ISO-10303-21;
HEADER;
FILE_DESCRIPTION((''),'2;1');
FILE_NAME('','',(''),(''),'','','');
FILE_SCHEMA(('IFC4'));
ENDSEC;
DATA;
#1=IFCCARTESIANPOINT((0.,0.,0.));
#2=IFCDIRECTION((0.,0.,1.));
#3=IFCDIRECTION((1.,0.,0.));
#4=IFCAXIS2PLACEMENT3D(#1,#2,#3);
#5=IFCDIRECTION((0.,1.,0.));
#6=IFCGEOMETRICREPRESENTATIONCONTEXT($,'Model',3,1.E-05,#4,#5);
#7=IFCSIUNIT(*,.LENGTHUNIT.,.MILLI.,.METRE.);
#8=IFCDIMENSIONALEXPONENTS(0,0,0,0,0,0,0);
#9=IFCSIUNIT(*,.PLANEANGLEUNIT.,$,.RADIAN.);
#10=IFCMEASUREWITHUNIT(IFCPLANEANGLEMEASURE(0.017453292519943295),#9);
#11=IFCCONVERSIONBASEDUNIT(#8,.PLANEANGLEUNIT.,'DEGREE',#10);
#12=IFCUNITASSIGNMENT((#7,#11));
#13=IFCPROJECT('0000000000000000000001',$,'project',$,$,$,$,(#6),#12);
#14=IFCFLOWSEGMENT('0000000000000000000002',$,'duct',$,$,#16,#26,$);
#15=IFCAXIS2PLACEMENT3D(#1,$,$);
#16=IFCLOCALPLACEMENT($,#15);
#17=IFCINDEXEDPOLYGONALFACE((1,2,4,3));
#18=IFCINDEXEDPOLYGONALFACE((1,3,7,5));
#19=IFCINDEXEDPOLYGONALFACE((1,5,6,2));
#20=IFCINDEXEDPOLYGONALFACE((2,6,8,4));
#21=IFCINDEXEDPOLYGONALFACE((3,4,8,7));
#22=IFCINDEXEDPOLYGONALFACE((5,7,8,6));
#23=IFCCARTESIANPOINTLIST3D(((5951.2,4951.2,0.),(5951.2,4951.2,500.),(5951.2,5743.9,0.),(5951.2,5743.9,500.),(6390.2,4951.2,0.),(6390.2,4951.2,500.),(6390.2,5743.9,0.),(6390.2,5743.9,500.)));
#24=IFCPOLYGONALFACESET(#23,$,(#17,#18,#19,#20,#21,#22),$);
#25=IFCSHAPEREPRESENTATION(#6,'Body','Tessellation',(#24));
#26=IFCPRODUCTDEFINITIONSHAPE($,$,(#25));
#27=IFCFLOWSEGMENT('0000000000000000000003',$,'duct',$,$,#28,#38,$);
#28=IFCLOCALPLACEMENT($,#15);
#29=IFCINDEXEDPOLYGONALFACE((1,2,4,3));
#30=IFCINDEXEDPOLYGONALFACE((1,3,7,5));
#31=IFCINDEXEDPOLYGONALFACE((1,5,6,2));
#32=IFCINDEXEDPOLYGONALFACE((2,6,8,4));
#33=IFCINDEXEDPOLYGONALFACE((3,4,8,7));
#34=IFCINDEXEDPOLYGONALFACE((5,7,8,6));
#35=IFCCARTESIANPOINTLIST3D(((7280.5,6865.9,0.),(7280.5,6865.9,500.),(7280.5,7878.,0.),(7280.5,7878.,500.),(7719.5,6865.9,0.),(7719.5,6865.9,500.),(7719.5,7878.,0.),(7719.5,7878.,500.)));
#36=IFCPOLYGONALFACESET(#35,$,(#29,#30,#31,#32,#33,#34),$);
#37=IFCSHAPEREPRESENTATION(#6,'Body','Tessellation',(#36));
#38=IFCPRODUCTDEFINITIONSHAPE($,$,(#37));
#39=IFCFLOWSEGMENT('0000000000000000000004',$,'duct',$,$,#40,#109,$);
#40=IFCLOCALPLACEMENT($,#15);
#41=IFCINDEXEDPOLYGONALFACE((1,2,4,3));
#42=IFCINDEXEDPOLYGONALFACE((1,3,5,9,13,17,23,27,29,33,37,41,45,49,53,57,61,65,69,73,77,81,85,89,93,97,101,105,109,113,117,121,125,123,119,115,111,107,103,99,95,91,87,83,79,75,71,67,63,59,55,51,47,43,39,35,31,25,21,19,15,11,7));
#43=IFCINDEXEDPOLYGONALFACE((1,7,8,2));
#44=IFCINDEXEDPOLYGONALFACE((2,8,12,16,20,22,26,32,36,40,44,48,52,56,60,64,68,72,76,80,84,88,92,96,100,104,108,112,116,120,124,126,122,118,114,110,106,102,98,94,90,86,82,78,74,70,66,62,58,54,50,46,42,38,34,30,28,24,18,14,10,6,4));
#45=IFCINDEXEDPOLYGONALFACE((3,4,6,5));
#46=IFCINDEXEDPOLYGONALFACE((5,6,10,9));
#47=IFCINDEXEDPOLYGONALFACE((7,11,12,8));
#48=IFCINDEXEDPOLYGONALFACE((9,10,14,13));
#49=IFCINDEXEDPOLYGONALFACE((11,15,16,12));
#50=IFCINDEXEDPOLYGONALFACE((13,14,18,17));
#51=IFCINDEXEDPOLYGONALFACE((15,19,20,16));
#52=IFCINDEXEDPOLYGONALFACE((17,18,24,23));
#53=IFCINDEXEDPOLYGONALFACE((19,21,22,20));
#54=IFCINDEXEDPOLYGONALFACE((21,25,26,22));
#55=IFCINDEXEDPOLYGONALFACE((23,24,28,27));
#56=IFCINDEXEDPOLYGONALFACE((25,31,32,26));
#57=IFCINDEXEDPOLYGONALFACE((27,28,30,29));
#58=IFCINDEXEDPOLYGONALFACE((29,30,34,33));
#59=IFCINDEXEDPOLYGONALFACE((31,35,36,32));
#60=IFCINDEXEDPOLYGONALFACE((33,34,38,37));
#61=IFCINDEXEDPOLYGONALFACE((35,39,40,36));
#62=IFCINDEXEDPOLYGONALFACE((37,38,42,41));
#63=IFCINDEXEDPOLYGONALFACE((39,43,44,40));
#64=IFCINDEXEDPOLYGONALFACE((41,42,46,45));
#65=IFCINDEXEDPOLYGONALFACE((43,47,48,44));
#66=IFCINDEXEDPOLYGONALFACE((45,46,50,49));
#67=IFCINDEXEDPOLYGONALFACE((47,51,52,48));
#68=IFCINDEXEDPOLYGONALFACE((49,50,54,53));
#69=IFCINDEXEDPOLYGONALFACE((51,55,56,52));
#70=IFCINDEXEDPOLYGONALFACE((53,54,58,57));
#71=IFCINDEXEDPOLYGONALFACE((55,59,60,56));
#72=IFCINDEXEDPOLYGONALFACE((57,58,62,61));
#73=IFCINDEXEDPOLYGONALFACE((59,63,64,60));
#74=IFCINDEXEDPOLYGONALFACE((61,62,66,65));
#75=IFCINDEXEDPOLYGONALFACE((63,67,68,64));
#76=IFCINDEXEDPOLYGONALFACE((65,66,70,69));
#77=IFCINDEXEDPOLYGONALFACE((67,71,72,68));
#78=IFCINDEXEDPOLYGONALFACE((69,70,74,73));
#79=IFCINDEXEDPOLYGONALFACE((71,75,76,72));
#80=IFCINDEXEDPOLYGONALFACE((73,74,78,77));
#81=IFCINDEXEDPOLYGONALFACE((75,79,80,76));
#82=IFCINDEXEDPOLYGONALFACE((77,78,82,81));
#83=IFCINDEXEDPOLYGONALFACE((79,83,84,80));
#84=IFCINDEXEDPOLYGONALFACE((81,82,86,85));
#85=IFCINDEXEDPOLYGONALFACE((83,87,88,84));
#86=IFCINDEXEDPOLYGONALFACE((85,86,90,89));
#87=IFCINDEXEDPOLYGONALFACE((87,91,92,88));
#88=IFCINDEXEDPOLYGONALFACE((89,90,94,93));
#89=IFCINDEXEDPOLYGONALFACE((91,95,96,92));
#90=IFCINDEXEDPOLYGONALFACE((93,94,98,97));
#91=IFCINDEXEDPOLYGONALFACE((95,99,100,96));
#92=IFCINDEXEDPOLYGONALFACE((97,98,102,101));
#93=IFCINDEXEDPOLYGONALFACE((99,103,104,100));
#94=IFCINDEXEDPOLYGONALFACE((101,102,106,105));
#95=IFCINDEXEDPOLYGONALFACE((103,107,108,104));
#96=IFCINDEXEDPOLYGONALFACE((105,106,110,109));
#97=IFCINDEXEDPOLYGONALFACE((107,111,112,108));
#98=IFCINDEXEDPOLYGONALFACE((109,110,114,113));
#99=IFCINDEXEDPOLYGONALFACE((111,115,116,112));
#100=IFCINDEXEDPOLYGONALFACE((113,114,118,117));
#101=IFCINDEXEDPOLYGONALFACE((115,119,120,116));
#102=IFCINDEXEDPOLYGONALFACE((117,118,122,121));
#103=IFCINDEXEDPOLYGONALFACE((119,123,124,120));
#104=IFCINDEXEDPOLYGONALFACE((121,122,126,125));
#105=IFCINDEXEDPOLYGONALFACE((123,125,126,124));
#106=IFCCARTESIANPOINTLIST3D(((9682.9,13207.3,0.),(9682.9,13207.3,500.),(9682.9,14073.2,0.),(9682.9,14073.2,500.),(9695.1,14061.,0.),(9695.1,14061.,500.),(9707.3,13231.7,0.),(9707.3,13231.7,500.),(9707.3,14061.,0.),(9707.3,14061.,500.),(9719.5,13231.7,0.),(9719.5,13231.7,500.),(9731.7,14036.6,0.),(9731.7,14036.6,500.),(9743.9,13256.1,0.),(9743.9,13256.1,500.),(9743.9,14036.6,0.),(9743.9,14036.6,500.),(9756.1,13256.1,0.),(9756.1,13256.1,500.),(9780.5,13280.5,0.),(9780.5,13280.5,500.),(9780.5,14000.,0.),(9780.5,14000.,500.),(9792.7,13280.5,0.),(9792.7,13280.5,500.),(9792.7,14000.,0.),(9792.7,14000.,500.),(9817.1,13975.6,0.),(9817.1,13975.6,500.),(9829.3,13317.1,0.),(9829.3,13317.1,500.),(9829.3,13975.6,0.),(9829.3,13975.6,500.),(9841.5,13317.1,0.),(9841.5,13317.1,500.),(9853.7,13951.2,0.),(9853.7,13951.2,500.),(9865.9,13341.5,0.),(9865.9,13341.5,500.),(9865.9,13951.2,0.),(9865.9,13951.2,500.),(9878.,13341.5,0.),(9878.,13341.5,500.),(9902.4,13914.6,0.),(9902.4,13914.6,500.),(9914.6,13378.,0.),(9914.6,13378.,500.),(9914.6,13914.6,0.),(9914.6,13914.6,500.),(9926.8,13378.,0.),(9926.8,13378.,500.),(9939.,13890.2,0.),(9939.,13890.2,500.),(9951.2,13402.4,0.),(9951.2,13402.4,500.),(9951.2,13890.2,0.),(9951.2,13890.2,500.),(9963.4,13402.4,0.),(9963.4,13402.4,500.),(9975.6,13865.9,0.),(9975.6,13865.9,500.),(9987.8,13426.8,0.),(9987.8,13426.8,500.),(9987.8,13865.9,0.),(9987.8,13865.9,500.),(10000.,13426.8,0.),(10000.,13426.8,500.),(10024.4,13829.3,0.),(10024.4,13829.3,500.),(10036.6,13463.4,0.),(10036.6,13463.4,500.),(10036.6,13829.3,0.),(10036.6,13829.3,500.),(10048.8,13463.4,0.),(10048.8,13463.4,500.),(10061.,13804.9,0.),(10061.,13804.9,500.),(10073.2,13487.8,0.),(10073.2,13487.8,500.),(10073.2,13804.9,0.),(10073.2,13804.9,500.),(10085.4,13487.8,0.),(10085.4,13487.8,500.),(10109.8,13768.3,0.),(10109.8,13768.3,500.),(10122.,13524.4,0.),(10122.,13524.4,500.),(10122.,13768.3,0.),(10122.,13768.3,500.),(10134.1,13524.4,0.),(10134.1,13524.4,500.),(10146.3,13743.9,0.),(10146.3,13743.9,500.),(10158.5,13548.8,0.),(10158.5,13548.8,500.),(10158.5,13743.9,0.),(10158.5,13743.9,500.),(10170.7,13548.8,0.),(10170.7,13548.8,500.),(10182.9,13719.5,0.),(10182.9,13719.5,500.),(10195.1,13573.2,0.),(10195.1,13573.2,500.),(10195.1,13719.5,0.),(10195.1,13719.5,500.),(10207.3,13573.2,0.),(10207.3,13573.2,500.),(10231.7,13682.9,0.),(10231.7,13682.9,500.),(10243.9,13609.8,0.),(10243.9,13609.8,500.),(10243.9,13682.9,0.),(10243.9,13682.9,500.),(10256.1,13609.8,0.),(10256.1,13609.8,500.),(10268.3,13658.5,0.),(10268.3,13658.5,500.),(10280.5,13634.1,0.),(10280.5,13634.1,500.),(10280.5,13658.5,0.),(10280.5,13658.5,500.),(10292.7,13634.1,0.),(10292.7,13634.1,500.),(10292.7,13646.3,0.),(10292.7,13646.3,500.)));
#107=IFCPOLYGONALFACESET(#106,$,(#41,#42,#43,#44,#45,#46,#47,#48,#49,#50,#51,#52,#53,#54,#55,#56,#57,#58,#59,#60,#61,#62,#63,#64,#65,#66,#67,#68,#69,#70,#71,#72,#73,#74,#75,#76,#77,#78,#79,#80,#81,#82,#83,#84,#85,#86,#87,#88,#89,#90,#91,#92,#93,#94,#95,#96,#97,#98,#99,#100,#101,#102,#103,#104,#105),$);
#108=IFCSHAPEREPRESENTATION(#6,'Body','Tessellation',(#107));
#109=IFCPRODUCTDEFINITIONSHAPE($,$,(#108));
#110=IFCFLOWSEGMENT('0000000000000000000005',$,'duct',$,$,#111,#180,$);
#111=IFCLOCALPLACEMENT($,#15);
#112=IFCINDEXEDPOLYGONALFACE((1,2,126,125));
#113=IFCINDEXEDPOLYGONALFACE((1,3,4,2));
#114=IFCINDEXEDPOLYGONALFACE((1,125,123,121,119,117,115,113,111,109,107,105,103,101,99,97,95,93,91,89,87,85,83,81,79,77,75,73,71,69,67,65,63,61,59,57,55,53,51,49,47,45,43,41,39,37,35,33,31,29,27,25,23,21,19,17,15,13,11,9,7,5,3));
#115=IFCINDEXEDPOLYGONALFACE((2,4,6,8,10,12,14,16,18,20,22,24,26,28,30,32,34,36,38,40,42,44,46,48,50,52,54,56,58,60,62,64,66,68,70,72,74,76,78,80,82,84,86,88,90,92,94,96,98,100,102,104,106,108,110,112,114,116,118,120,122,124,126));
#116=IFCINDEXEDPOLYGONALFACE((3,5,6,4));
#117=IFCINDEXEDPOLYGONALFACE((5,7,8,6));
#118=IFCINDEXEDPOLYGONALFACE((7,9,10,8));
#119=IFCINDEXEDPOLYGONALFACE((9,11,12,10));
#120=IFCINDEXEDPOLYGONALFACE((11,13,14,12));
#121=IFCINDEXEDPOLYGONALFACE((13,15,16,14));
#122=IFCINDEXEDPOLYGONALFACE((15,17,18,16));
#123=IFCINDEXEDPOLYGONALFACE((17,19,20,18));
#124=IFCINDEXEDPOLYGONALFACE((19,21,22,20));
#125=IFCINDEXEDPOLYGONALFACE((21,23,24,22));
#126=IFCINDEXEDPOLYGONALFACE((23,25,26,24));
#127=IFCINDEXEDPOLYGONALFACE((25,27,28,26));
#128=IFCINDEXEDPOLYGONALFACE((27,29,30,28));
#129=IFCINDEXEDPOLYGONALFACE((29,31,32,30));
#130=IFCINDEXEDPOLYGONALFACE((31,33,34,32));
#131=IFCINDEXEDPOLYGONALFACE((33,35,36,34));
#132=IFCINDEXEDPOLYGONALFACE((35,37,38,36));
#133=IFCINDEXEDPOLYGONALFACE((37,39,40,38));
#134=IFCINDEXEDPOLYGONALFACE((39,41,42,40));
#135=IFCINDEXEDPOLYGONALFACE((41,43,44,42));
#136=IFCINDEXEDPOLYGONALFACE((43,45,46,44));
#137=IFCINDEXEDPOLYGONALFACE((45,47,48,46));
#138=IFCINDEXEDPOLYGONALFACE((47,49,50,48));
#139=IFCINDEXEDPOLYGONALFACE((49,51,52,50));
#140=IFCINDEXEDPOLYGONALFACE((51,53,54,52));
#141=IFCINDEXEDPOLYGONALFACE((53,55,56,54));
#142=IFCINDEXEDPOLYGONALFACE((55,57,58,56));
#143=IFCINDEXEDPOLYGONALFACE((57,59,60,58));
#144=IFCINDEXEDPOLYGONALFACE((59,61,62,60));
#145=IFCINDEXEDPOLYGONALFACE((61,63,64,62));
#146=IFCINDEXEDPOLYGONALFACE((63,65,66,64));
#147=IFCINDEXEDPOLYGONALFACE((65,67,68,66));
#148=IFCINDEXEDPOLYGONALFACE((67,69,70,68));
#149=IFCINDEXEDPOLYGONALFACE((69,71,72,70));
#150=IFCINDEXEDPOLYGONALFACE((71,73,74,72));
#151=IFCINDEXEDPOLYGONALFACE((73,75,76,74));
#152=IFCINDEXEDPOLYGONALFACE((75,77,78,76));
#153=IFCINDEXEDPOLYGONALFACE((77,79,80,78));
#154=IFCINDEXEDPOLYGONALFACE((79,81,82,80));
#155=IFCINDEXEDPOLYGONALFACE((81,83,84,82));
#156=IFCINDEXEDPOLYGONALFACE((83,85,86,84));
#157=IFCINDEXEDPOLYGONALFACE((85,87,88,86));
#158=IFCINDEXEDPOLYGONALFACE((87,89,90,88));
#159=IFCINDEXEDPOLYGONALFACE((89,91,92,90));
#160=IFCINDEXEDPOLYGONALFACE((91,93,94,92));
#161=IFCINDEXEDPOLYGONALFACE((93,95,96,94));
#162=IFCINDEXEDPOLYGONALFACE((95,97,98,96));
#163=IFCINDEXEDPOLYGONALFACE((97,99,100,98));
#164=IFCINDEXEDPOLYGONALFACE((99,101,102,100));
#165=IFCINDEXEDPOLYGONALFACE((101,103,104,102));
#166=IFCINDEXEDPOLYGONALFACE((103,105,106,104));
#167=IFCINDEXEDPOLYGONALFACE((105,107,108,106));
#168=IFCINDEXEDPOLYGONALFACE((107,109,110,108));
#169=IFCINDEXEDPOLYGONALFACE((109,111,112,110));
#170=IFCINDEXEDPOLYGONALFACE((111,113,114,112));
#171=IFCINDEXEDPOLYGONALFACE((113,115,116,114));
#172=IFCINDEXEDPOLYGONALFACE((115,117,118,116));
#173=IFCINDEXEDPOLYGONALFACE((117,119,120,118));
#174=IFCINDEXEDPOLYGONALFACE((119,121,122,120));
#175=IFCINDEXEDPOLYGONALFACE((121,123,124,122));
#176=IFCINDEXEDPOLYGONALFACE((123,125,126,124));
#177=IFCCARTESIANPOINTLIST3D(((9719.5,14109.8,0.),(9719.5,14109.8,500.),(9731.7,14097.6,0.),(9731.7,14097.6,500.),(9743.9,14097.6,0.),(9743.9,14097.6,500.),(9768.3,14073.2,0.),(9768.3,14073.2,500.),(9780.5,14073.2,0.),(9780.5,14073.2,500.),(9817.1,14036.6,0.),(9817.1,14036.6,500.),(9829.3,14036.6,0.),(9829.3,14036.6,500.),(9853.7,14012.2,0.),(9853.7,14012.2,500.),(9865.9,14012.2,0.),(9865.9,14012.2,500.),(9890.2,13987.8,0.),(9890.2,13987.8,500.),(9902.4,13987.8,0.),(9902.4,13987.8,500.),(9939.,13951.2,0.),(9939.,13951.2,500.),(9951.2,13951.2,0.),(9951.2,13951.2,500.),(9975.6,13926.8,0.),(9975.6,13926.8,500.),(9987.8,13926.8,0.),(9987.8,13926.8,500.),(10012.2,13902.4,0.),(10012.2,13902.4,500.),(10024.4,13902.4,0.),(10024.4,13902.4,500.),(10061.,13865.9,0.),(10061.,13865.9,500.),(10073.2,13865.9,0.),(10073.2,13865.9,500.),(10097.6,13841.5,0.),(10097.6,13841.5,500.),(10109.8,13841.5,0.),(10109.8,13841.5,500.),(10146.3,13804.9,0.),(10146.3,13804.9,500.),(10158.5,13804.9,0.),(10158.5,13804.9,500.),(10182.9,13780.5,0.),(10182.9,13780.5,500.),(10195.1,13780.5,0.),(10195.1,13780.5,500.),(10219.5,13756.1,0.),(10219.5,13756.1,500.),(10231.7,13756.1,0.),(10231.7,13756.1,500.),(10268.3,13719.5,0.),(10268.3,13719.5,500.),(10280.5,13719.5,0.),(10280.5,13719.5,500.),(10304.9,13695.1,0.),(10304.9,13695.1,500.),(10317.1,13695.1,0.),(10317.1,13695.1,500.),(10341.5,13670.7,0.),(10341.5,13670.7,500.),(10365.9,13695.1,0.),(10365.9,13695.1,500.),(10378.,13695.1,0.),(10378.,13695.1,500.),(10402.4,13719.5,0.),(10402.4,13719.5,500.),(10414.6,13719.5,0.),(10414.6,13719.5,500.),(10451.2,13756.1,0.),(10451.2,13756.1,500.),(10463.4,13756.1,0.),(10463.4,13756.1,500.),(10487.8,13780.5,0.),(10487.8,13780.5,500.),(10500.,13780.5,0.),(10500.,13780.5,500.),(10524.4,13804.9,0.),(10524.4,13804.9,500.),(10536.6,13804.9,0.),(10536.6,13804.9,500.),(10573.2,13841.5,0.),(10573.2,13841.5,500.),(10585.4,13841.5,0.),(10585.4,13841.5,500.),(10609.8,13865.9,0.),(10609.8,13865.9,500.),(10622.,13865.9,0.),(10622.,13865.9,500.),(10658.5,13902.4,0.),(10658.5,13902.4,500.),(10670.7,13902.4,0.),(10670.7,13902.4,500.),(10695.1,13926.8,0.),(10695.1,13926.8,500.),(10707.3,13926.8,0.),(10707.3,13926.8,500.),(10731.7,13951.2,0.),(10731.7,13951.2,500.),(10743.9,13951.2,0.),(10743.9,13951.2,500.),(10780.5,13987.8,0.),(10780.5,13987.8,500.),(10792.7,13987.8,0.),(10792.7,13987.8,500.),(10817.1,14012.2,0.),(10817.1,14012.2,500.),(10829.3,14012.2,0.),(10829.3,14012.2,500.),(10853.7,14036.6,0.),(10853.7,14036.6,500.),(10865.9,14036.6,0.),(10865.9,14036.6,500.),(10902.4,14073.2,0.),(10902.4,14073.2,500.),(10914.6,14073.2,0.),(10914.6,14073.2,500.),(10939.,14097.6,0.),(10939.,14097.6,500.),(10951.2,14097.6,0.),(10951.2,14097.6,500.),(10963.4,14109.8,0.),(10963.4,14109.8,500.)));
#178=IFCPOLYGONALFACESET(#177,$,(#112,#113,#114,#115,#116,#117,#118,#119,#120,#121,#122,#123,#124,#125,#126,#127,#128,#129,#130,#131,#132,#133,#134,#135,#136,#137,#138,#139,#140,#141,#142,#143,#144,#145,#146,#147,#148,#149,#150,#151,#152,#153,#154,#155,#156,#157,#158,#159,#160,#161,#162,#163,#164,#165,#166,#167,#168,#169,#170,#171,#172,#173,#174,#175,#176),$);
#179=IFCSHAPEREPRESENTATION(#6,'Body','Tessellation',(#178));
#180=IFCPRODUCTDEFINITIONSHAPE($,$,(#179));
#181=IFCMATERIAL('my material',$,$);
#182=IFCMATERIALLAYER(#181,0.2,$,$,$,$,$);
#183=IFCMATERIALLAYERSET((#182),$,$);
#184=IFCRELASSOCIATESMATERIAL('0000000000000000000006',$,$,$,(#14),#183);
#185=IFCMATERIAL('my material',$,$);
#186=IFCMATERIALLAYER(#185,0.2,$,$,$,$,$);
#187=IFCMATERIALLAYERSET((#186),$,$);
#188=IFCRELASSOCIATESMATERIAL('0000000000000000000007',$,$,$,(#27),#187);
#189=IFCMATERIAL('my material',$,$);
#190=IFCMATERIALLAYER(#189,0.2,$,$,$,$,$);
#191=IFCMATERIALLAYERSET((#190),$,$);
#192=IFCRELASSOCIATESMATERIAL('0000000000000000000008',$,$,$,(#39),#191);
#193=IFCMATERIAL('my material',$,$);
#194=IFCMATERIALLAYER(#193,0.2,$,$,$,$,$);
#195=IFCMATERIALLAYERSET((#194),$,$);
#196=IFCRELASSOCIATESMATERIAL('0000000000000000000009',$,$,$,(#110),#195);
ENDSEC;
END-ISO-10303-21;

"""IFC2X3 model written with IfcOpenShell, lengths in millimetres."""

from ifc_helpers import new_model, entity, si_unit, converted_unit, direction, origin_with_axes, place, context, project, polyline, outline, extrude, material, layer, layer_set, layer_usage, element, save


model = new_model("IFC2X3")

# Units and contexts
model_context = context("Model", 3, precision=1e-05, world=origin_with_axes(), true_north=direction((0.0, 1.0, 0.0)))
ifc_project = project(units=[si_unit("LENGTHUNIT", "METRE", prefix="MILLI"), converted_unit("PLANEANGLEUNIT", "DEGREE", entity("IfcPlaneAngleMeasure", 0.017453292519943295), si_unit("PLANEANGLEUNIT", "RADIAN"), dimensions=[0, 0, 0, 0, 0, 0, 0])], contexts=[model_context])

# Flow segments
ifc_material_1 = material(Name="my material")
ifc_layer_1 = layer(ifc_material_1, 0.2)
ifc_layer_set_1 = layer_set([ifc_layer_1])
ifc_layer_usage_1 = layer_usage(ifc_layer_set_1, "AXIS2", "POSITIVE", -0.1)
flow_segment_1_placement = place(None, origin_with_axes())
element("IfcFlowSegment", 1, at=flow_segment_1_placement, material=ifc_layer_usage_1, Name="duct", context=model_context, shape_type="SweptSolid", body=[
    extrude(outline(polyline([(5951.2, 4951.2), (6390.2, 4951.2), (6390.2, 5743.9), (5951.2, 5743.9), (5951.2, 4951.2)])), origin_with_axes(), (0.0, 0.0, 1.0), 500.0),
])
ifc_material_2 = material(Name="my material")
ifc_layer_2 = layer(ifc_material_2, 0.2)
ifc_layer_set_2 = layer_set([ifc_layer_2])
ifc_layer_usage_2 = layer_usage(ifc_layer_set_2, "AXIS2", "POSITIVE", -0.1)
flow_segment_2_placement = place(None, origin_with_axes())
element("IfcFlowSegment", 2, at=flow_segment_2_placement, material=ifc_layer_usage_2, Name="duct", context=model_context, shape_type="SweptSolid", body=[
    extrude(outline(polyline([(7280.5, 6865.9), (7719.5, 6865.9), (7719.5, 7878.0), (7280.5, 7878.0), (7280.5, 6865.9)])), origin_with_axes(), (0.0, 0.0, 1.0), 500.0),
])
ifc_material_3 = material(Name="my material")
ifc_layer_3 = layer(ifc_material_3, 0.2)
ifc_layer_set_3 = layer_set([ifc_layer_3])
ifc_layer_usage_3 = layer_usage(ifc_layer_set_3, "AXIS2", "POSITIVE", -0.1)
flow_segment_3_placement = place(None, origin_with_axes())
element("IfcFlowSegment", 3, at=flow_segment_3_placement, material=ifc_layer_usage_3, Name="duct", context=model_context, shape_type="SweptSolid", body=[
    extrude(outline(polyline([(9682.9, 13207.3), (9707.3, 13231.7), (9719.5, 13231.7), (9743.9, 13256.1), (9756.1, 13256.1), (9780.5, 13280.5), (9792.7, 13280.5), (9829.3, 13317.1), (9841.5, 13317.1), (9865.9, 13341.5), (9878.0, 13341.5), (9914.6, 13378.0), (9926.8, 13378.0), (9951.2, 13402.4), (9963.4, 13402.4), (9987.8, 13426.8), (10000.0, 13426.8), (10036.6, 13463.4), (10048.8, 13463.4), (10073.2, 13487.8), (10085.4, 13487.8), (10122.0, 13524.4), (10134.1, 13524.4), (10158.5, 13548.8), (10170.7, 13548.8), (10195.1, 13573.2), (10207.3, 13573.2), (10243.9, 13609.8), (10256.1, 13609.8), (10280.5, 13634.1), (10292.7, 13634.1), (10292.7, 13646.3), (10280.5, 13658.5), (10268.3, 13658.5), (10243.9, 13682.9), (10231.7, 13682.9), (10195.1, 13719.5), (10182.9, 13719.5), (10158.5, 13743.9), (10146.3, 13743.9), (10122.0, 13768.3), (10109.8, 13768.3), (10073.2, 13804.9), (10061.0, 13804.9), (10036.6, 13829.3), (10024.4, 13829.3), (9987.8, 13865.9), (9975.6, 13865.9), (9951.2, 13890.2), (9939.0, 13890.2), (9914.6, 13914.6), (9902.4, 13914.6), (9865.9, 13951.2), (9853.7, 13951.2), (9829.3, 13975.6), (9817.1, 13975.6), (9792.7, 14000.0), (9780.5, 14000.0), (9743.9, 14036.6), (9731.7, 14036.6), (9707.3, 14061.0), (9695.1, 14061.0), (9682.9, 14073.2), (9682.9, 13207.3)])), origin_with_axes(), (0.0, 0.0, 1.0), 500.0),
])
ifc_material_4 = material(Name="my material")
ifc_layer_4 = layer(ifc_material_4, 0.2)
ifc_layer_set_4 = layer_set([ifc_layer_4])
ifc_layer_usage_4 = layer_usage(ifc_layer_set_4, "AXIS2", "POSITIVE", -0.1)
flow_segment_4_placement = place(None, origin_with_axes())
element("IfcFlowSegment", 4, at=flow_segment_4_placement, material=ifc_layer_usage_4, Name="duct", context=model_context, shape_type="SweptSolid", body=[
    extrude(outline(polyline([(9719.5, 14109.8), (9731.7, 14097.6), (9743.9, 14097.6), (9768.3, 14073.2), (9780.5, 14073.2), (9817.1, 14036.6), (9829.3, 14036.6), (9853.7, 14012.2), (9865.9, 14012.2), (9890.2, 13987.8), (9902.4, 13987.8), (9939.0, 13951.2), (9951.2, 13951.2), (9975.6, 13926.8), (9987.8, 13926.8), (10012.2, 13902.4), (10024.4, 13902.4), (10061.0, 13865.9), (10073.2, 13865.9), (10097.6, 13841.5), (10109.8, 13841.5), (10146.3, 13804.9), (10158.5, 13804.9), (10182.9, 13780.5), (10195.1, 13780.5), (10219.5, 13756.1), (10231.7, 13756.1), (10268.3, 13719.5), (10280.5, 13719.5), (10304.9, 13695.1), (10317.1, 13695.1), (10341.5, 13670.7), (10365.9, 13695.1), (10378.0, 13695.1), (10402.4, 13719.5), (10414.6, 13719.5), (10451.2, 13756.1), (10463.4, 13756.1), (10487.8, 13780.5), (10500.0, 13780.5), (10524.4, 13804.9), (10536.6, 13804.9), (10573.2, 13841.5), (10585.4, 13841.5), (10609.8, 13865.9), (10622.0, 13865.9), (10658.5, 13902.4), (10670.7, 13902.4), (10695.1, 13926.8), (10707.3, 13926.8), (10731.7, 13951.2), (10743.9, 13951.2), (10780.5, 13987.8), (10792.7, 13987.8), (10817.1, 14012.2), (10829.3, 14012.2), (10853.7, 14036.6), (10865.9, 14036.6), (10902.4, 14073.2), (10914.6, 14073.2), (10939.0, 14097.6), (10951.2, 14097.6), (10963.4, 14109.8), (9719.5, 14109.8)])), origin_with_axes(), (0.0, 0.0, 1.0), 500.0),
])

save(model, "model.ifc")
